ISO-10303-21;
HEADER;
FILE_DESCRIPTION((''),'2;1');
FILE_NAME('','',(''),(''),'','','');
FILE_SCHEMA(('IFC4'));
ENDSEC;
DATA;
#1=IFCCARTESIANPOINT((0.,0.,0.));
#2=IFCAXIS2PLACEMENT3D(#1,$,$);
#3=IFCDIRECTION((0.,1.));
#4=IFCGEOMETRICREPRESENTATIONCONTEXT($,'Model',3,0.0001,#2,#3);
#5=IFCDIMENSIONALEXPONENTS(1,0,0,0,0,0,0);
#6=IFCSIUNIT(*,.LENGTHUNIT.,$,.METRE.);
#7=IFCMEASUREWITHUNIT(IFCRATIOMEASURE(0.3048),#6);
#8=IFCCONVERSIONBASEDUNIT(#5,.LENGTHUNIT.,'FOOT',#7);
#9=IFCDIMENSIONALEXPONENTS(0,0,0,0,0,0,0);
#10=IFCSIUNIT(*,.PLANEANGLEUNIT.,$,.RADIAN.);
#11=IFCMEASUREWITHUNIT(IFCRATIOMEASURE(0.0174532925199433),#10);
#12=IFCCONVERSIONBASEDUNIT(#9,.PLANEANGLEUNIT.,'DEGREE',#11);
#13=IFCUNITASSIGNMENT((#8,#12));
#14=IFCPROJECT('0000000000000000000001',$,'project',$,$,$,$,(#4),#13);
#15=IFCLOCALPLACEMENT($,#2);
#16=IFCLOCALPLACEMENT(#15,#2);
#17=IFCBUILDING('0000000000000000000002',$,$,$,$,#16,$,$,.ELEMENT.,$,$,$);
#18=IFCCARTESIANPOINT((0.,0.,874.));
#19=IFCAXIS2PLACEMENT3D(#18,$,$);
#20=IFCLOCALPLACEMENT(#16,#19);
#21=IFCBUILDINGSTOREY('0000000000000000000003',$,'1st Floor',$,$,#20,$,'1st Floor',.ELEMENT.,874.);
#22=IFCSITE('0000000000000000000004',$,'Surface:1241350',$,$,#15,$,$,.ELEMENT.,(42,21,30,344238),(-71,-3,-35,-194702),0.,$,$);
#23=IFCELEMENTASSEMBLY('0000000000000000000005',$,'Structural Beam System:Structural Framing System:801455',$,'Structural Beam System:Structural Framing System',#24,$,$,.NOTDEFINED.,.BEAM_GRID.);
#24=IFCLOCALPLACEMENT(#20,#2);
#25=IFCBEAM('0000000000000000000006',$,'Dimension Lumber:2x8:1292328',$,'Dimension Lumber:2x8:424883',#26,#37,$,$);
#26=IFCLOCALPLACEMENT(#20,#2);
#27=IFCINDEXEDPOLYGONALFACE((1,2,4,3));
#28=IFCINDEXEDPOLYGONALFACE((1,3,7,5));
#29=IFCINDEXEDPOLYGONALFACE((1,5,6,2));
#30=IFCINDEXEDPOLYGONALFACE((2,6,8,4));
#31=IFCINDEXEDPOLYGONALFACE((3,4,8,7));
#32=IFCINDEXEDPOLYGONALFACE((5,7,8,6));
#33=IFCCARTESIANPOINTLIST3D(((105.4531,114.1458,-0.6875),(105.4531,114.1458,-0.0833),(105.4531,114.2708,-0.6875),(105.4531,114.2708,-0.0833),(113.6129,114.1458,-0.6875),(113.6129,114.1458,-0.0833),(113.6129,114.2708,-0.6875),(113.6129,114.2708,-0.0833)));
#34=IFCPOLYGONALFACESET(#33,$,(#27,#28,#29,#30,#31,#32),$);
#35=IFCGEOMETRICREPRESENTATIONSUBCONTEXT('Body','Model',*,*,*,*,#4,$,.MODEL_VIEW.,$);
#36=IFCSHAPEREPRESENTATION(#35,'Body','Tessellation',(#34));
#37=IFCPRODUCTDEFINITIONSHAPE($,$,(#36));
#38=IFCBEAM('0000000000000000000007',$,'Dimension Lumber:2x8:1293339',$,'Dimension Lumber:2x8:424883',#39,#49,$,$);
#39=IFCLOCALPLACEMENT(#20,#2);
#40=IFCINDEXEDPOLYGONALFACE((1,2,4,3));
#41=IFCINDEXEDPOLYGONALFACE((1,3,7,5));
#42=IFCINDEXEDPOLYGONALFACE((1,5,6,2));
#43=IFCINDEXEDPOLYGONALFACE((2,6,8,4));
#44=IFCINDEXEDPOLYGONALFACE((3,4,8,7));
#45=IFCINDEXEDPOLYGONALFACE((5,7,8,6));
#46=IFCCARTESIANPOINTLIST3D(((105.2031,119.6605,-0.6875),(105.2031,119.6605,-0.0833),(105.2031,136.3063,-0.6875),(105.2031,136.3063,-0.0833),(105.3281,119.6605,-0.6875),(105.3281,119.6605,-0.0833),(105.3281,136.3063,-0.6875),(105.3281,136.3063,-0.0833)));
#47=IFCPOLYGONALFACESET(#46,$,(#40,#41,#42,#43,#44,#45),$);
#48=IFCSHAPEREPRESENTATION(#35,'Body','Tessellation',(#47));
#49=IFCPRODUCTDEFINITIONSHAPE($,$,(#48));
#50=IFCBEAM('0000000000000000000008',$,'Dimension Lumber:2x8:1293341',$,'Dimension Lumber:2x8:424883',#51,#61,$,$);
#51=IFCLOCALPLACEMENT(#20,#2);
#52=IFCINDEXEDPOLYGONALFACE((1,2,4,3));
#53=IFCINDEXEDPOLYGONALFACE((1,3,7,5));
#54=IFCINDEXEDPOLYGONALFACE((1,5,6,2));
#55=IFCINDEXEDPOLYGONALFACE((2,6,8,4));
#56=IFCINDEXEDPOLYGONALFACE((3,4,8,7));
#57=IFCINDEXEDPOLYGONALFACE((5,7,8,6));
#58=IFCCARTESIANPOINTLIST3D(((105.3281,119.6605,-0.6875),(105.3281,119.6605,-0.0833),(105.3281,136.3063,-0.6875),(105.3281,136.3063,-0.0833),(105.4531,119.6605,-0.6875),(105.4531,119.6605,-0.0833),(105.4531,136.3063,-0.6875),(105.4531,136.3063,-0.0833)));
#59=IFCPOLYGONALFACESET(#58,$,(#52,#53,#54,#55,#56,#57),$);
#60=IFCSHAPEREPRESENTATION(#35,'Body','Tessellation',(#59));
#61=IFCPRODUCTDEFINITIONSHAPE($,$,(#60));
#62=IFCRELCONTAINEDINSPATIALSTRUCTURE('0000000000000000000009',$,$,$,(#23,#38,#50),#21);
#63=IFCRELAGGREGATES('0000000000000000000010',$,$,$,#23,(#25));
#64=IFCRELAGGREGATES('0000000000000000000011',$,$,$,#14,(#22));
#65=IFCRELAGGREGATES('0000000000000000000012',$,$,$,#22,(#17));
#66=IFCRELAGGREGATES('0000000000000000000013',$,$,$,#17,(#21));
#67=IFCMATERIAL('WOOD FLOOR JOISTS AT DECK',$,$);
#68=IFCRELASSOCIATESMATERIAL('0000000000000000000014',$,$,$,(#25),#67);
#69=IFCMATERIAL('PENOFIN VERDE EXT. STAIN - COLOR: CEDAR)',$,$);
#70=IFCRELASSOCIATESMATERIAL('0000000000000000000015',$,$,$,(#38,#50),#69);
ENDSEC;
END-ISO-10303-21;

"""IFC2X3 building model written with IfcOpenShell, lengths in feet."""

from ifc_helpers import new_model, entity, si_unit, converted_unit, direction, frame, frame_2d, origin, origin_2d_with_axis, place, context, subcontext, project, spatial, rectangle, extrude, material, element, aggregate, save


model = new_model("IFC2X3")

# Units and contexts
model_context = context("Model", 3, precision=0.0001, world=origin(), true_north=direction((0.0, 1.0)))
body_context = subcontext(model_context, "Body", "Model", "MODEL_VIEW")
ifc_project = project(units=[converted_unit("LENGTHUNIT", "FOOT", entity("IfcRatioMeasure", 0.3048), si_unit("LENGTHUNIT", "METRE"), dimensions=[1, 0, 0, 0, 0, 0, 0]), converted_unit("PLANEANGLEUNIT", "DEGREE", entity("IfcRatioMeasure", 0.0174532925199433), si_unit("PLANEANGLEUNIT", "RADIAN"), dimensions=[0, 0, 0, 0, 0, 0, 0])], contexts=[model_context])

# Site, building, storey
site_placement = place(None, origin())
site = spatial("IfcSite", under=ifc_project, at=site_placement, Name="Surface:1241350", CompositionType="ELEMENT", RefLatitude=(42, 21, 30, 344238), RefLongitude=(-71, -3, -35, -194702), RefElevation=0.0)
building_placement = place(site_placement, origin())
building = spatial("IfcBuilding", under=site, at=building_placement, CompositionType="ELEMENT")
storey_placement = place(building_placement, frame((0.0, 0.0, 874.0)))
storey = spatial("IfcBuildingStorey", under=building, at=storey_placement, Name="1st Floor", LongName="1st Floor", CompositionType="ELEMENT", Elevation=874.0)

# Element assembly, beam
assembly_placement = place(storey_placement, origin())
assembly = element("IfcElementAssembly", 1, at=assembly_placement, inside=storey, Name="Structural Beam System:Structural Framing System:801455", ObjectType="Structural Beam System:Structural Framing System", AssemblyPlace="NOTDEFINED", PredefinedType="BEAM_GRID")
ifc_material_1 = material(Name="WOOD FLOOR JOISTS AT DECK")
beam_1_placement = place(assembly_placement, frame((105.3906, 114.2083, 0.0)))
beam_1 = element("IfcBeam", 2, at=beam_1_placement, material=ifc_material_1, Name="Dimension Lumber:2x8:1292328", ObjectType="Dimension Lumber:2x8:424883", context=body_context, shape_type="SweptSolid", body=[
    extrude(rectangle(XDim=0.6042, YDim=0.125, at=origin_2d_with_axis()), frame((0.0625, 0.0, -0.3854), z_axis=(1.0, 0.0, 0.0), x_axis=(0.0, 0.0, -1.0)), (0.0, 0.0, 1.0), 8.1598),
])
aggregate(assembly, [beam_1])

# Beams
ifc_material_2 = material(Name="PENOFIN VERDE EXT. STAIN - COLOR: CEDAR)")
for number, where, z_axis, x_axis, name in (
    (3, (105.2656, 119.6605, 0.0), (0.0, 0.0, 1.0), (0.0, 1.0, 0.0), "Dimension Lumber:2x8:1293339"),
    (4, (105.3906, 119.6605, 0.0), (0.0, 0.0, 1.0), (0.0, 1.0, 0.0), "Dimension Lumber:2x8:1293341"),
):
    element("IfcBeam", number, at=place(storey_placement, frame(where, z_axis=z_axis, x_axis=x_axis)), inside=storey, material=ifc_material_2, Name=name, ObjectType="Dimension Lumber:2x8:424883", context=body_context, shape_type="SweptSolid", body=[
        extrude(rectangle(XDim=0.6042, YDim=0.125, at=frame_2d((0.0, 0.0), x_axis=(1.0, 0.0))), frame((0.0, 0.0, -0.3854), z_axis=(1.0, 0.0, 0.0), x_axis=(0.0, 0.0, -1.0)), (0.0, 0.0, 1.0), 16.6458),
    ])

save(model, "model.ifc")
